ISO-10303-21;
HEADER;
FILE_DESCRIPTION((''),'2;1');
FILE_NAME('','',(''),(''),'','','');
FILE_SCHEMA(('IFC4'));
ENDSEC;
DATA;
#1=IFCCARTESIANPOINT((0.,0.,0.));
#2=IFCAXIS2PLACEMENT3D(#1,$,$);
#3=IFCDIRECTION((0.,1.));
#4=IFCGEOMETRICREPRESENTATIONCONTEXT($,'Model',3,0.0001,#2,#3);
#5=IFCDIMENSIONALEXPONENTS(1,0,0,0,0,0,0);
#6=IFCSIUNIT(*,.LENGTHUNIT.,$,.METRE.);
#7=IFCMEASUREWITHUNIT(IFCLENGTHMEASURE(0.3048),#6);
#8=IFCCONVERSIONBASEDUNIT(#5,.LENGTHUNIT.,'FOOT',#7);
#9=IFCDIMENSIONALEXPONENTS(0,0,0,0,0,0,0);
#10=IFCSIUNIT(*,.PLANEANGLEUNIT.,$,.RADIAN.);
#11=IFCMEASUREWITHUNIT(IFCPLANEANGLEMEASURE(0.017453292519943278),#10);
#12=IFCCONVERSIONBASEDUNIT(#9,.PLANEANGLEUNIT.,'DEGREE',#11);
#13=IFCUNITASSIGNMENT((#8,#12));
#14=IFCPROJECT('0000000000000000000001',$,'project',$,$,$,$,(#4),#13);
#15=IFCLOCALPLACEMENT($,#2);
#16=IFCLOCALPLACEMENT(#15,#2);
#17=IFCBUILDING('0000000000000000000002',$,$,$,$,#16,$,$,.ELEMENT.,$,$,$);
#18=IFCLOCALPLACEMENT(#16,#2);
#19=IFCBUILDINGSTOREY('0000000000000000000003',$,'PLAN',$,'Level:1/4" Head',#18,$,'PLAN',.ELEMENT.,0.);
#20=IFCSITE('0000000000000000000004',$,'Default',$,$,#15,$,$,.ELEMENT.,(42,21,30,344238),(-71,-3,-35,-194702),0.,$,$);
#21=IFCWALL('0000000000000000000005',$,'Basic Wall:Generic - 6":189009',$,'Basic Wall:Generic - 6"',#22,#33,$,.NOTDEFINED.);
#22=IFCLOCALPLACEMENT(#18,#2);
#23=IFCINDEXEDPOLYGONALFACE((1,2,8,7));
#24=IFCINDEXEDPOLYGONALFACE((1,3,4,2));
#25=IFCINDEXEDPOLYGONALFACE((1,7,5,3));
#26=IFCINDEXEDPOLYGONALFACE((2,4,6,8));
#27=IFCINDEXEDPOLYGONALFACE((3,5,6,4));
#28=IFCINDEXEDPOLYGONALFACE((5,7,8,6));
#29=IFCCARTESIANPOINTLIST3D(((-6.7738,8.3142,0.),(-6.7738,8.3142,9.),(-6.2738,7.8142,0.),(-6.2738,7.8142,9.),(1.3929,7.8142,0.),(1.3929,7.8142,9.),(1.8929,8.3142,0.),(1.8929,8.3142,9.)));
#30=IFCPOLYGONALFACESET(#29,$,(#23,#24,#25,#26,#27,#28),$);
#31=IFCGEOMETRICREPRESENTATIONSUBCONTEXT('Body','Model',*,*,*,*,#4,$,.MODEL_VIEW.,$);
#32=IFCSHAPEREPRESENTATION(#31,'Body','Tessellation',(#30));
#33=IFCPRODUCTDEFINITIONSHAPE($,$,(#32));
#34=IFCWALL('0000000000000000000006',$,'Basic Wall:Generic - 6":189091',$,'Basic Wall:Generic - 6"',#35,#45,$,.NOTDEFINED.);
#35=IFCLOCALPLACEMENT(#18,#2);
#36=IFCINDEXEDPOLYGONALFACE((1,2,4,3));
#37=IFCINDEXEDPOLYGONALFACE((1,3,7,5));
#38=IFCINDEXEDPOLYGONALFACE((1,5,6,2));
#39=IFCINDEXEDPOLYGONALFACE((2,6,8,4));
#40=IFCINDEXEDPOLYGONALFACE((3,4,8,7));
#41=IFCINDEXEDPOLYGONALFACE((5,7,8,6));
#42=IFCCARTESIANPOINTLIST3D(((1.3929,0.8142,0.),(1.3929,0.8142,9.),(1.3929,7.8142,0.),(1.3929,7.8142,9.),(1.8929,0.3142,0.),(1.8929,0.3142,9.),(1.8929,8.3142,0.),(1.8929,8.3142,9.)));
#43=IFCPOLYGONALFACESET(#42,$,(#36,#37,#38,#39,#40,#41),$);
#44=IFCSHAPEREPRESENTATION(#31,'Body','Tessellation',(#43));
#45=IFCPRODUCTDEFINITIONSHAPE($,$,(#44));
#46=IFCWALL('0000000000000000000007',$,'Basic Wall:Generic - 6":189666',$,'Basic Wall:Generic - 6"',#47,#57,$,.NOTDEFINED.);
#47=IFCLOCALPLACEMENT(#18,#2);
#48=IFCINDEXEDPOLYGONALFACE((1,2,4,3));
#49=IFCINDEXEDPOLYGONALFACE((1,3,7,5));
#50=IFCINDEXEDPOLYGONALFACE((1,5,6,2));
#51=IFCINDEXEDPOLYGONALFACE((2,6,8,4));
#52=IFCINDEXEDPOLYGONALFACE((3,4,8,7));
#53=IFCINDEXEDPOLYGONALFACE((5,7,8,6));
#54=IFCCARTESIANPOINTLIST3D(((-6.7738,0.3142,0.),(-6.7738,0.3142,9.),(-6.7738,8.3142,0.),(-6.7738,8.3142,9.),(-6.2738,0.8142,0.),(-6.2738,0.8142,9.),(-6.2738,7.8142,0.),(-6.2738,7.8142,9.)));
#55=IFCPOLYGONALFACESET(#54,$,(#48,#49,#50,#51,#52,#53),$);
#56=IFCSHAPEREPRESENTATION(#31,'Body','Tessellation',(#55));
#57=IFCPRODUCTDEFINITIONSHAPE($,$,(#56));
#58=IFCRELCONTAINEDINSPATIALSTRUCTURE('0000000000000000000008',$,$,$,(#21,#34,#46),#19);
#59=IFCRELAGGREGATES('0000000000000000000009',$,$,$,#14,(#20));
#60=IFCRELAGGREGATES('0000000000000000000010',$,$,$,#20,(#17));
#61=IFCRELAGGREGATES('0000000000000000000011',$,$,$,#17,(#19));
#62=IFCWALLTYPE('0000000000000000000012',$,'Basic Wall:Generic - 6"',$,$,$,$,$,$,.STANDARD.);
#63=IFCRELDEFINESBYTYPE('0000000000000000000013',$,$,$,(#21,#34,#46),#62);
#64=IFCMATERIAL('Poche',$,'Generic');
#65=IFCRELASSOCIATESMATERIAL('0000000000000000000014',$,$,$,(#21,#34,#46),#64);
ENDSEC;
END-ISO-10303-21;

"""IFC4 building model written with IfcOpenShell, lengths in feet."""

from ifc_helpers import new_model, entity, si_unit, converted_unit, direction, frame, origin, place, context, subcontext, project, spatial, indexed_curve, outline, extrude, material, type_object, element, save


model = new_model("IFC4")

# Units and contexts
model_context = context("Model", 3, precision=0.0001, world=origin(), true_north=direction((0.0, 1.0)))
body_context = subcontext(model_context, "Body", "Model", "MODEL_VIEW")
ifc_project = project(units=[converted_unit("LENGTHUNIT", "FOOT", entity("IfcLengthMeasure", 0.3048), si_unit("LENGTHUNIT", "METRE"), dimensions=[1, 0, 0, 0, 0, 0, 0]), converted_unit("PLANEANGLEUNIT", "DEGREE", entity("IfcPlaneAngleMeasure", 0.017453292519943278), si_unit("PLANEANGLEUNIT", "RADIAN"), dimensions=[0, 0, 0, 0, 0, 0, 0])], contexts=[model_context])

# Site, building, storey
site_placement = place(None, origin())
site = spatial("IfcSite", under=ifc_project, at=site_placement, Name="Default", CompositionType="ELEMENT", RefLatitude=(42, 21, 30, 344238), RefLongitude=(-71, -3, -35, -194702), RefElevation=0.0)
building_placement = place(site_placement, origin())
building = spatial("IfcBuilding", under=site, at=building_placement, CompositionType="ELEMENT")
storey_placement = place(building_placement, origin())
storey = spatial("IfcBuildingStorey", under=building, at=storey_placement, Name="PLAN", ObjectType="Level:1/4\" Head", LongName="PLAN", CompositionType="ELEMENT", Elevation=0.0)

# Walls
ifc_material_1 = material(Name="Poche", Category="Generic")
wall_type = type_object("IfcWallType", Name="Basic Wall:Generic - 6\"", PredefinedType="STANDARD")
wall_1_placement = place(storey_placement, frame((-6.7738, 8.0642, 0.0)))
element("IfcWall", 1, at=wall_1_placement, inside=storey, type_object=wall_type, material=ifc_material_1, Name="Basic Wall:Generic - 6\":189009", ObjectType="Basic Wall:Generic - 6\"", PredefinedType="NOTDEFINED", context=body_context, shape_type="SweptSolid", body=[
    extrude(outline(indexed_curve([(8.1667, -0.25), (8.6667, 0.25), (0.0, 0.25), (0.5, -0.25), (8.1667, -0.25)], self_intersect=False)), origin(), (0.0, 0.0, 1.0), 9.0),
])
wall_2_placement = place(storey_placement, frame((1.6429, 8.3142, 0.0), z_axis=(0.0, 0.0, 1.0), x_axis=(0.0, -1.0, 0.0)))
element("IfcWall", 2, at=wall_2_placement, inside=storey, type_object=wall_type, material=ifc_material_1, Name="Basic Wall:Generic - 6\":189091", ObjectType="Basic Wall:Generic - 6\"", PredefinedType="NOTDEFINED", context=body_context, shape_type="SweptSolid", body=[
    extrude(outline(indexed_curve([(7.5, -0.25), (8.0, 0.25), (0.0, 0.25), (0.5, -0.25), (7.5, -0.25)], self_intersect=False)), origin(), (0.0, 0.0, 1.0), 9.0),
])
wall_3_placement = place(storey_placement, frame((-6.5238, 0.3142, 0.0), z_axis=(0.0, 0.0, 1.0), x_axis=(0.0, 1.0, 0.0)))
element("IfcWall", 3, at=wall_3_placement, inside=storey, type_object=wall_type, material=ifc_material_1, Name="Basic Wall:Generic - 6\":189666", ObjectType="Basic Wall:Generic - 6\"", PredefinedType="NOTDEFINED", context=body_context, shape_type="SweptSolid", body=[
    extrude(outline(indexed_curve([(7.5, -0.25), (8.0, 0.25), (0.0, 0.25), (0.5, -0.25), (7.5, -0.25)], self_intersect=False)), origin(), (0.0, 0.0, 1.0), 9.0),
])

save(model, "model.ifc")
